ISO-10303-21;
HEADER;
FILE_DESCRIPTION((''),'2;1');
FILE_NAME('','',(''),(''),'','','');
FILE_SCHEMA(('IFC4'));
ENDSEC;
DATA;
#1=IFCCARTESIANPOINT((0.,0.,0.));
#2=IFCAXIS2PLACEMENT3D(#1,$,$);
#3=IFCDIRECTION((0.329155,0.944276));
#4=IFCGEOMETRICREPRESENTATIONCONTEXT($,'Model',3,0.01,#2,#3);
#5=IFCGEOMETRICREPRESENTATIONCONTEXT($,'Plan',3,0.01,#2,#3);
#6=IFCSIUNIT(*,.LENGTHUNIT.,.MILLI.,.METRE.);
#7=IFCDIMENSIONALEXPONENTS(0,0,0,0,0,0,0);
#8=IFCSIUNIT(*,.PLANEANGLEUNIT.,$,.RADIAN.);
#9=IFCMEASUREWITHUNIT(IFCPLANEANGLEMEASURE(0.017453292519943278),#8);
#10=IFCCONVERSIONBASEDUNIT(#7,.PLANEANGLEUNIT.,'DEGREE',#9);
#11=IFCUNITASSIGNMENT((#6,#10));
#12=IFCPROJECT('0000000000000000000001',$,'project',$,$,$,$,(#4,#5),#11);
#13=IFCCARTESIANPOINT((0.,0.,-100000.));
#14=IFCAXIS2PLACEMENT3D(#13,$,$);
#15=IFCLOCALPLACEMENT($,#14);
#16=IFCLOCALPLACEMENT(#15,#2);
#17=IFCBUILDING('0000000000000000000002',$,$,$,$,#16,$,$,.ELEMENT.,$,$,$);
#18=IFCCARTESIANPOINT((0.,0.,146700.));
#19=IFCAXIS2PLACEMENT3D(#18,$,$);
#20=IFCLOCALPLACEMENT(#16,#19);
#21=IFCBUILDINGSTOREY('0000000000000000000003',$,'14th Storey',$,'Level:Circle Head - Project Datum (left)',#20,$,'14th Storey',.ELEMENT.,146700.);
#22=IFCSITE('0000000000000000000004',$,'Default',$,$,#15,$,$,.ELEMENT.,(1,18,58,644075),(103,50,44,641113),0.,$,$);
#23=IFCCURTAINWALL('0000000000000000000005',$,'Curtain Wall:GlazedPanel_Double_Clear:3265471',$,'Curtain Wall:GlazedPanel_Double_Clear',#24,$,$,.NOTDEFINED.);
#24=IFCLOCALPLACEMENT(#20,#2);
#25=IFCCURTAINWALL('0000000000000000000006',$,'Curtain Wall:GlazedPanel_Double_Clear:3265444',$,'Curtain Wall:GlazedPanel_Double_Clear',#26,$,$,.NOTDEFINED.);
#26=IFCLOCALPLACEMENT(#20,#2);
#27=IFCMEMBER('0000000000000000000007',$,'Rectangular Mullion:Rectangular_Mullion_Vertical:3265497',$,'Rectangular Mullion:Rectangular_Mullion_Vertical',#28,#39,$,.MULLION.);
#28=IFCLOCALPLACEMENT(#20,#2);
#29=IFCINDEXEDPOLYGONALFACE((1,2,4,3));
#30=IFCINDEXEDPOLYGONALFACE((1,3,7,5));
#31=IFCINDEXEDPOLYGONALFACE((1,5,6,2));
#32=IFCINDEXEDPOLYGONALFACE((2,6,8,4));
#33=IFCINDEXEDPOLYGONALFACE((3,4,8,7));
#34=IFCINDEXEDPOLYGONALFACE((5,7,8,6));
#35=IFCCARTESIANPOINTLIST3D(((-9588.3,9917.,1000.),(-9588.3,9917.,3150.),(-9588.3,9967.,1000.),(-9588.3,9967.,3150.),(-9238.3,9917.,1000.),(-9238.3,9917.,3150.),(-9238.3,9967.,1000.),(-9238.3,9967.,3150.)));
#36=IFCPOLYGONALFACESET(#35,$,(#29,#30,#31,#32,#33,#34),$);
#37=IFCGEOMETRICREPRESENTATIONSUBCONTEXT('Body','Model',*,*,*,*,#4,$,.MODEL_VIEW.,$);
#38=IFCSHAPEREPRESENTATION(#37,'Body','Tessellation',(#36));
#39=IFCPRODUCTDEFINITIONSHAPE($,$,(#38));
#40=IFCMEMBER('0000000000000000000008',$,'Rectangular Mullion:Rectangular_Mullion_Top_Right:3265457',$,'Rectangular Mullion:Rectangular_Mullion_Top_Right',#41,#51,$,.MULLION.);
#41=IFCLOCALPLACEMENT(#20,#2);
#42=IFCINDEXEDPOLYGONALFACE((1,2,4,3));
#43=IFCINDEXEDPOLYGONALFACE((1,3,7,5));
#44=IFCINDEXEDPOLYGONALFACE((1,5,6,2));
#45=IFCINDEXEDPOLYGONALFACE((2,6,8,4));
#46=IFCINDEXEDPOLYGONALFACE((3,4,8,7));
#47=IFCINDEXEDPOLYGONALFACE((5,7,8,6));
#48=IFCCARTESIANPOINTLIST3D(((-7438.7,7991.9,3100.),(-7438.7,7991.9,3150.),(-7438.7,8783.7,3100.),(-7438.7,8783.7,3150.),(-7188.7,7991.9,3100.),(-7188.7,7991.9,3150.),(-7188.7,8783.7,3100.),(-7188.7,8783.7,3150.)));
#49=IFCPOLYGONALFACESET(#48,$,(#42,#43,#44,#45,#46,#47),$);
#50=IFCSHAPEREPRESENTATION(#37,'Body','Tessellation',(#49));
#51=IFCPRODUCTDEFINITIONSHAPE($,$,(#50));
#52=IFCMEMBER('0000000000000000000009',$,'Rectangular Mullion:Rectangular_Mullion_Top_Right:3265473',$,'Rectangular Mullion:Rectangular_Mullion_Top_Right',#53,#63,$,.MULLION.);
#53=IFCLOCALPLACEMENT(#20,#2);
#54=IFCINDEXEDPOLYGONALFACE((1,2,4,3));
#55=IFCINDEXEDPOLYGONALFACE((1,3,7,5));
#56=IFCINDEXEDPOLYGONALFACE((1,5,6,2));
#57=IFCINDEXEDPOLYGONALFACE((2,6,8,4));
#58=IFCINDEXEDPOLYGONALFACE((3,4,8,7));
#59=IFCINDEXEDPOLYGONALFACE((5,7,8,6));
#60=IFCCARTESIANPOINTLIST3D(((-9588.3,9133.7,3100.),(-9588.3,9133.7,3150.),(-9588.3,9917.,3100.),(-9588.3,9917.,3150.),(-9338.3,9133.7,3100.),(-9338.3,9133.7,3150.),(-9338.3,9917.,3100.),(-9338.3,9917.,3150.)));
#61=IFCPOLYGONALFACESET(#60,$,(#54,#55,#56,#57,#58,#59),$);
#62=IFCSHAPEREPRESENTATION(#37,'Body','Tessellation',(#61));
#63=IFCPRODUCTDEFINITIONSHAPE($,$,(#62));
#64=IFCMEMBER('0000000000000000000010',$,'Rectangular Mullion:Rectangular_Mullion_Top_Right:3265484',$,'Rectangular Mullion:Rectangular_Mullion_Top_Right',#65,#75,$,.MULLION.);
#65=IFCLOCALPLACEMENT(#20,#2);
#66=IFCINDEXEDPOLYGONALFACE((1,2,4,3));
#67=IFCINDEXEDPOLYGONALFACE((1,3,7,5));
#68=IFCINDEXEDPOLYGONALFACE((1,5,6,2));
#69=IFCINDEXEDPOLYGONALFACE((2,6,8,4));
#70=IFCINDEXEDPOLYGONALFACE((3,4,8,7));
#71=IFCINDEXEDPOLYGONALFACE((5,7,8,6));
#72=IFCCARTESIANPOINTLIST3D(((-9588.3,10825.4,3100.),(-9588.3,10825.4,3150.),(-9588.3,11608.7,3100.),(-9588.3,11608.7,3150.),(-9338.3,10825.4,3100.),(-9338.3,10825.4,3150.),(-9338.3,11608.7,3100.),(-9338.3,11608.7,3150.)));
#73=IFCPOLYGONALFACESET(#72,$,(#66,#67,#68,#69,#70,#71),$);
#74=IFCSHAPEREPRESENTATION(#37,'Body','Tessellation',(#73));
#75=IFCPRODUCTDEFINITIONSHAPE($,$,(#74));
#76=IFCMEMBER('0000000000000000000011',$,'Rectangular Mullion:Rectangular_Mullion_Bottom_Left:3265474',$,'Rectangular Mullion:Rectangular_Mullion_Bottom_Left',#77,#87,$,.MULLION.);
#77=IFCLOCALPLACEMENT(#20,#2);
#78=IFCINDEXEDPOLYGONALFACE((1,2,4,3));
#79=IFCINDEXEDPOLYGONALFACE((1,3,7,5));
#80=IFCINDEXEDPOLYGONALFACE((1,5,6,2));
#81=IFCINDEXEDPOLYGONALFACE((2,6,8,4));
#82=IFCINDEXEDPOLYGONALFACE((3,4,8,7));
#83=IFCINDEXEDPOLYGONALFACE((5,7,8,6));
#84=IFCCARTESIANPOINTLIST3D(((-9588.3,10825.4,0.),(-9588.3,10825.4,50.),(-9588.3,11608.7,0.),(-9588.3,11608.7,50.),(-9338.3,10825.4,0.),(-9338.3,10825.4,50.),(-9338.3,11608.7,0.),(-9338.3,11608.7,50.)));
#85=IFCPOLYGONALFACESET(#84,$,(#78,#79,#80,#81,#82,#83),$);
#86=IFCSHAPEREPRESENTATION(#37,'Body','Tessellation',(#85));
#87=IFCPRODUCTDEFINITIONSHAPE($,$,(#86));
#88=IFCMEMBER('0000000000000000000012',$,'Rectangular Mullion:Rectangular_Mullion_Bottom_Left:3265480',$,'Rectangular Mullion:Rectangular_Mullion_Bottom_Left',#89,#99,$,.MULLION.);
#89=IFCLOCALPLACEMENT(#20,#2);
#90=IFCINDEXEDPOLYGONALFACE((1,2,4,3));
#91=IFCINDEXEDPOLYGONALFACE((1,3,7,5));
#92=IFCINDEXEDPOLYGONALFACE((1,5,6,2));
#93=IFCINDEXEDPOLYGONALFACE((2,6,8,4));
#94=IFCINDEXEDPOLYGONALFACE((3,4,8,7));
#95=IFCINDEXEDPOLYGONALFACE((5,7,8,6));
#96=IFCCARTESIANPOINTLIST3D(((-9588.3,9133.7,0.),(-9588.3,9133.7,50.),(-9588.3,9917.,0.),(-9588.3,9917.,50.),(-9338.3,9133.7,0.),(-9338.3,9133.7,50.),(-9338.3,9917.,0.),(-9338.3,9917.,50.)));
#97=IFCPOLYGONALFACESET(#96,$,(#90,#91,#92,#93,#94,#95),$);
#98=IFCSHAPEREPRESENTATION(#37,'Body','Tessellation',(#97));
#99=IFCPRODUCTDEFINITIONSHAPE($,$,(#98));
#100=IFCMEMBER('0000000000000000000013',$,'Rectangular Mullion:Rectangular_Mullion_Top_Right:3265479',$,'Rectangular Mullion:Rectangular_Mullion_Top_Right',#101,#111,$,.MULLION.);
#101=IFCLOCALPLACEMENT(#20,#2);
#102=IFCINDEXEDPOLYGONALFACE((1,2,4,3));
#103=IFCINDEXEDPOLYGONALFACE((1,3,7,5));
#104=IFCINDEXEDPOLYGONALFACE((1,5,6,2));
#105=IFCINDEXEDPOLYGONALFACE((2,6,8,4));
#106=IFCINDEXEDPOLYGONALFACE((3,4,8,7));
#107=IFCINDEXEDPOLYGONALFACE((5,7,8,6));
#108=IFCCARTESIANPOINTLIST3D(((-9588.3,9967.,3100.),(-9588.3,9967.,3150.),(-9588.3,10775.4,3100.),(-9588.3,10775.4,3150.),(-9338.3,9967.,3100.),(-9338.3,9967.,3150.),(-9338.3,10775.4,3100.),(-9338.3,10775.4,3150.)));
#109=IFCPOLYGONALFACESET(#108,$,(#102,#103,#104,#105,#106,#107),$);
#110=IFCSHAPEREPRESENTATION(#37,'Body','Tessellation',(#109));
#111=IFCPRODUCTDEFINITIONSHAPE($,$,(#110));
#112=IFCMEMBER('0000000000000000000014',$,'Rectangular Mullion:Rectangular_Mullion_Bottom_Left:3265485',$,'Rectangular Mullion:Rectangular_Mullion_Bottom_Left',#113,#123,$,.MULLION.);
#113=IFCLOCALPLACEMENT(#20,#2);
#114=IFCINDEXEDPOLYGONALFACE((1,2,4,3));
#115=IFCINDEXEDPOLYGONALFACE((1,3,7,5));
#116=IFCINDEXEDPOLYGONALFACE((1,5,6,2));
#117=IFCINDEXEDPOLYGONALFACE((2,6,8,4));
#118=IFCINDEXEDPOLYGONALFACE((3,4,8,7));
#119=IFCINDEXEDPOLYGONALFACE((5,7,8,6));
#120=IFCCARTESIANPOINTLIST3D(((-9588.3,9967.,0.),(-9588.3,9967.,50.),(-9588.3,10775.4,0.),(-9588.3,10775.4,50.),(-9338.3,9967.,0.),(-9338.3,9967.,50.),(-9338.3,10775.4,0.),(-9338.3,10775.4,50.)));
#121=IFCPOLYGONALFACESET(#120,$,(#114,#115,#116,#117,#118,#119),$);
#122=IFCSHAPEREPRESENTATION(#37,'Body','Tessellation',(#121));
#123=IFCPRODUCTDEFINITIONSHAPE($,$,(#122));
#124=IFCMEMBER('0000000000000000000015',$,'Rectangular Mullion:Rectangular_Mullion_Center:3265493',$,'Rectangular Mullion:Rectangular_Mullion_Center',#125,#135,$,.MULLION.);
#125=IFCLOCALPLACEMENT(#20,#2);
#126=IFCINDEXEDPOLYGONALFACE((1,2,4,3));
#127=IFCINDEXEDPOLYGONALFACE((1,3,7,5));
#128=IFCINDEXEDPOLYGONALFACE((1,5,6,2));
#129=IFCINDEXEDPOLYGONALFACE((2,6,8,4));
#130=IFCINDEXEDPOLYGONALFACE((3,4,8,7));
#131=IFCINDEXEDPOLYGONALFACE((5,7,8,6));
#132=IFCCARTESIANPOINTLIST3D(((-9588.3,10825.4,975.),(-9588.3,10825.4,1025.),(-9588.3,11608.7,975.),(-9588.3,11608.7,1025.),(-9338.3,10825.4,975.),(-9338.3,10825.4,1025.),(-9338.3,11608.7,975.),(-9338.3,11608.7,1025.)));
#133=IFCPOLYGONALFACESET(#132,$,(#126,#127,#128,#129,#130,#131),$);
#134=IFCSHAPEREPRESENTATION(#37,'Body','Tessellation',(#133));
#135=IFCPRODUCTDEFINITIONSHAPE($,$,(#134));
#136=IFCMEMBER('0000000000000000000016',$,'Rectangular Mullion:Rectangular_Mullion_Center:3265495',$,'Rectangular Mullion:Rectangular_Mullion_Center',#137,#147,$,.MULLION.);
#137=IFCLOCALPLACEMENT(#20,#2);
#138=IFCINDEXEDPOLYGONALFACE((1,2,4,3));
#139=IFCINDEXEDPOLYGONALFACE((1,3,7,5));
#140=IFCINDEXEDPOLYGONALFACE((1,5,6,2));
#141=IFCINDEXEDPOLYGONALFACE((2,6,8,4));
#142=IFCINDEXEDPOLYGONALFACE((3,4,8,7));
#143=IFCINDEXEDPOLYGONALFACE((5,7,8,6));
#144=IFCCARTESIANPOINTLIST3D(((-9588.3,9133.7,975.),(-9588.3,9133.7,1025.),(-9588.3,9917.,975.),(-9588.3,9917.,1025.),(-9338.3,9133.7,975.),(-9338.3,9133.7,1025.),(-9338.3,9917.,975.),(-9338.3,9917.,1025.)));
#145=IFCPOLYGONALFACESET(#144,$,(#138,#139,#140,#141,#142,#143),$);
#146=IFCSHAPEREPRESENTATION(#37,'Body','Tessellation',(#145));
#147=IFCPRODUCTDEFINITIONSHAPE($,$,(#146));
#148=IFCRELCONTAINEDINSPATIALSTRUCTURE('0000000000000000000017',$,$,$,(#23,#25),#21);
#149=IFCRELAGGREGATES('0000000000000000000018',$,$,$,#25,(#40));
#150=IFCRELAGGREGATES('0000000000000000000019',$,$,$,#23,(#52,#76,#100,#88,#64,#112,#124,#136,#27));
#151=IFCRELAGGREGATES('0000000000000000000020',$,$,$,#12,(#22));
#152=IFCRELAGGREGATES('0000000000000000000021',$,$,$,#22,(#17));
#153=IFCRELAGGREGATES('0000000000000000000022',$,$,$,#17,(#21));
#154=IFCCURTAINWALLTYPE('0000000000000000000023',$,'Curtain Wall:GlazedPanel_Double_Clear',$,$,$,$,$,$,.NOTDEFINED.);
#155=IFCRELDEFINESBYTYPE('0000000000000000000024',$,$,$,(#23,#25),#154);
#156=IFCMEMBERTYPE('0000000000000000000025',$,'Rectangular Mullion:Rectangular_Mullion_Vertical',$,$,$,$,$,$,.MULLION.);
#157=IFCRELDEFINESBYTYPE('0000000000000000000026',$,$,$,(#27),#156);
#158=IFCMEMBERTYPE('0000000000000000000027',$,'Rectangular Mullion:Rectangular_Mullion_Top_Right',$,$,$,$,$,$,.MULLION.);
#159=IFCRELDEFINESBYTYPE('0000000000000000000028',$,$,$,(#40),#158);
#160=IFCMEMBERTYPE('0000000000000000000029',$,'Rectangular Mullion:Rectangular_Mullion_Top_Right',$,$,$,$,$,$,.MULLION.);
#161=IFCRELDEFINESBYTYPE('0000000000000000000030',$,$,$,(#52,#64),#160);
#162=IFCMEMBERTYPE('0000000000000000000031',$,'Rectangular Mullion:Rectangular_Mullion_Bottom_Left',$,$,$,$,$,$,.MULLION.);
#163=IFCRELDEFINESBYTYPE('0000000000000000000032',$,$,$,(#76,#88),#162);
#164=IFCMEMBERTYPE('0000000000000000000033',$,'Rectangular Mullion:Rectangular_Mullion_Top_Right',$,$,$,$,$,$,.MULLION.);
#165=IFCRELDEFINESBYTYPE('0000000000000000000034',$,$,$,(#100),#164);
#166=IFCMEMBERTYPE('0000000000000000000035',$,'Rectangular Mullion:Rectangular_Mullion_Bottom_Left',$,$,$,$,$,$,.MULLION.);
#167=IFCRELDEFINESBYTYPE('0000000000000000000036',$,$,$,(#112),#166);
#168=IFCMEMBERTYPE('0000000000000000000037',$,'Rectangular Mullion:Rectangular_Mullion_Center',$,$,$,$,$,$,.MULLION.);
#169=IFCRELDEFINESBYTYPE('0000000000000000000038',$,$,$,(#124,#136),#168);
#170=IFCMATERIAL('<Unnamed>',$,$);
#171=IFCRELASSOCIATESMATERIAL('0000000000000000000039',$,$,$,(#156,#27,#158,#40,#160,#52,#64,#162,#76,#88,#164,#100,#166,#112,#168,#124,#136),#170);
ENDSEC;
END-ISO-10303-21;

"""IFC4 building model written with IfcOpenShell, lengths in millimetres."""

from ifc_helpers import new_model, entity, si_unit, converted_unit, direction, frame, origin, place, context, subcontext, project, spatial, indexed_curve, outline, extrude, source, transform, mapped, material, type_object, type_shapes, element, aggregate, save


model = new_model("IFC4")

# Units and contexts
model_context = context("Model", 3, precision=0.01, world=origin(), true_north=direction((0.329155, 0.944276)))
plan_context = context("Plan", 3, precision=0.01, world=origin(), true_north=direction((0.329155, 0.944276)))
body_context = subcontext(model_context, "Body", "Model", "MODEL_VIEW")
ifc_project = project(units=[si_unit("LENGTHUNIT", "METRE", prefix="MILLI"), converted_unit("PLANEANGLEUNIT", "DEGREE", entity("IfcPlaneAngleMeasure", 0.017453292519943278), si_unit("PLANEANGLEUNIT", "RADIAN"), dimensions=[0, 0, 0, 0, 0, 0, 0])], contexts=[model_context, plan_context])

# Site, building, storey
site_placement = place(None, frame((0.0, 0.0, -100000.0)))
site = spatial("IfcSite", under=ifc_project, at=site_placement, Name="Default", CompositionType="ELEMENT", RefLatitude=(1, 18, 58, 644075), RefLongitude=(103, 50, 44, 641113), RefElevation=0.0)
building_placement = place(site_placement, origin())
building = spatial("IfcBuilding", under=site, at=building_placement, CompositionType="ELEMENT")
storey_placement = place(building_placement, frame((0.0, 0.0, 146700.0)))
storey = spatial("IfcBuildingStorey", under=building, at=storey_placement, Name="14th Storey", ObjectType="Level:Circle Head - Project Datum (left)", LongName="14th Storey", CompositionType="ELEMENT", Elevation=146700.0)

# Curtain walls
curtain_wall_type = type_object("IfcCurtainWallType", Name="Curtain Wall:GlazedPanel_Double_Clear", PredefinedType="NOTDEFINED")
curtain_wall_1_placement = place(storey_placement, frame((0.0, 0.0, -146700.0)))
curtain_wall_1 = element("IfcCurtainWall", 1, at=curtain_wall_1_placement, inside=storey, type_object=curtain_wall_type, Name="Curtain Wall:GlazedPanel_Double_Clear:3265471", ObjectType="Curtain Wall:GlazedPanel_Double_Clear", PredefinedType="NOTDEFINED")
ifc_material_1 = material(Name="<Unnamed>")
curtain_wall_2_placement = place(storey_placement, frame((0.0, 0.0, -146700.0)))
curtain_wall_2 = element("IfcCurtainWall", 2, at=curtain_wall_2_placement, inside=storey, type_object=curtain_wall_type, Name="Curtain Wall:GlazedPanel_Double_Clear:3265444", ObjectType="Curtain Wall:GlazedPanel_Double_Clear", PredefinedType="NOTDEFINED")

# Members
member_type_1 = type_object("IfcMemberType", Name="Rectangular Mullion:Rectangular_Mullion_Vertical", PredefinedType="MULLION", material=ifc_material_1)
shared_shape_1 = source(origin(), body_context, "Body", "SweptSolid", [
    extrude(outline(indexed_curve([(-25.0, -175.0), (25.0, -175.0), (25.0, 175.0), (-25.0, 175.0), (-25.0, -175.0)], self_intersect=False)), frame((0.0, -50.0, -2150.0), z_axis=(0.0, 0.0, 1.0), x_axis=(-1.0, 0.0, 0.0)), (0.0, 0.0, 1.0), 2150.0),
])
type_shapes(member_type_1, [shared_shape_1])
member_1_placement = place(curtain_wall_1_placement, frame((-9463.3, 9942.0, 147700.0), z_axis=(0.0, 0.0, -1.0), x_axis=(0.0, -1.0, 0.0)))
member_1 = element("IfcMember", 3, at=member_1_placement, type_object=member_type_1, material=ifc_material_1, Name="Rectangular Mullion:Rectangular_Mullion_Vertical:3265497", ObjectType="Rectangular Mullion:Rectangular_Mullion_Vertical", PredefinedType="MULLION", context=body_context, shape_type="MappedRepresentation", body=[
    mapped(shared_shape_1, transform((0.0, 0.0, 0.0), scale=1.0)),
])
member_type_2 = type_object("IfcMemberType", Name="Rectangular Mullion:Rectangular_Mullion_Top_Right", PredefinedType="MULLION", material=ifc_material_1)
shared_shape_2 = source(origin(), body_context, "Body", "SweptSolid", [
    extrude(outline(indexed_curve([(-25.0, -125.0), (25.0, -125.0), (25.0, 125.0), (-25.0, 125.0), (-25.0, -125.0)], self_intersect=False)), frame((-25.0, 0.0, -791.8), z_axis=(0.0, 0.0, 1.0), x_axis=(-1.0, 0.0, 0.0)), (0.0, 0.0, 1.0), 791.8),
])
type_shapes(member_type_2, [shared_shape_2])
member_2_placement = place(curtain_wall_2_placement, frame((-7313.7, 7991.9, 149850.0), z_axis=(0.0, -1.0, 0.0), x_axis=(0.0, 0.0, 1.0)))
member_2 = element("IfcMember", 4, at=member_2_placement, type_object=member_type_2, material=ifc_material_1, Name="Rectangular Mullion:Rectangular_Mullion_Top_Right:3265457", ObjectType="Rectangular Mullion:Rectangular_Mullion_Top_Right", PredefinedType="MULLION", context=body_context, shape_type="MappedRepresentation", body=[
    mapped(shared_shape_2, transform((0.0, 0.0, 0.0), scale=1.0)),
])
member_type_3 = type_object("IfcMemberType", Name="Rectangular Mullion:Rectangular_Mullion_Top_Right", PredefinedType="MULLION", material=ifc_material_1)
shared_shape_3 = source(origin(), body_context, "Body", "SweptSolid", [
    extrude(outline(indexed_curve([(-25.0, -125.0), (25.0, -125.0), (25.0, 125.0), (-25.0, 125.0), (-25.0, -125.0)], self_intersect=False)), frame((-25.0, 0.0, -783.3), z_axis=(0.0, 0.0, 1.0), x_axis=(-1.0, 0.0, 0.0)), (0.0, 0.0, 1.0), 783.3),
])
type_shapes(member_type_3, [shared_shape_3])
member_3_placement = place(curtain_wall_1_placement, frame((-9463.3, 9133.7, 149850.0), z_axis=(0.0, -1.0, 0.0), x_axis=(0.0, 0.0, 1.0)))
member_3 = element("IfcMember", 5, at=member_3_placement, type_object=member_type_3, material=ifc_material_1, Name="Rectangular Mullion:Rectangular_Mullion_Top_Right:3265473", ObjectType="Rectangular Mullion:Rectangular_Mullion_Top_Right", PredefinedType="MULLION", context=body_context, shape_type="MappedRepresentation", body=[
    mapped(shared_shape_3, transform((0.0, 0.0, 0.0), scale=1.0)),
])
member_4_placement = place(curtain_wall_1_placement, frame((-9463.3, 10825.4, 149850.0), z_axis=(0.0, -1.0, 0.0), x_axis=(0.0, 0.0, 1.0)))
member_4 = element("IfcMember", 6, at=member_4_placement, type_object=member_type_3, material=ifc_material_1, Name="Rectangular Mullion:Rectangular_Mullion_Top_Right:3265484", ObjectType="Rectangular Mullion:Rectangular_Mullion_Top_Right", PredefinedType="MULLION", context=body_context, shape_type="MappedRepresentation", body=[
    mapped(shared_shape_3, transform((0.0, 0.0, 0.0), scale=1.0)),
])
member_type_4 = type_object("IfcMemberType", Name="Rectangular Mullion:Rectangular_Mullion_Bottom_Left", PredefinedType="MULLION", material=ifc_material_1)
shared_shape_4 = source(origin(), body_context, "Body", "SweptSolid", [
    extrude(outline(indexed_curve([(-25.0, -125.0), (25.0, -125.0), (25.0, 125.0), (-25.0, 125.0), (-25.0, -125.0)], self_intersect=False)), frame((-25.0, 0.0, -783.3), z_axis=(0.0, 0.0, 1.0), x_axis=(-1.0, 0.0, 0.0)), (0.0, 0.0, 1.0), 783.3),
])
type_shapes(member_type_4, [shared_shape_4])
member_5_placement = place(curtain_wall_1_placement, frame((-9463.3, 11608.7, 146700.0), z_axis=(0.0, 1.0, 0.0), x_axis=(0.0, 0.0, -1.0)))
member_5 = element("IfcMember", 7, at=member_5_placement, type_object=member_type_4, material=ifc_material_1, Name="Rectangular Mullion:Rectangular_Mullion_Bottom_Left:3265474", ObjectType="Rectangular Mullion:Rectangular_Mullion_Bottom_Left", PredefinedType="MULLION", context=body_context, shape_type="MappedRepresentation", body=[
    mapped(shared_shape_4, transform((0.0, 0.0, 0.0), scale=1.0)),
])
member_6_placement = place(curtain_wall_1_placement, frame((-9463.3, 9917.0, 146700.0), z_axis=(0.0, 1.0, 0.0), x_axis=(0.0, 0.0, -1.0)))
member_6 = element("IfcMember", 8, at=member_6_placement, type_object=member_type_4, material=ifc_material_1, Name="Rectangular Mullion:Rectangular_Mullion_Bottom_Left:3265480", ObjectType="Rectangular Mullion:Rectangular_Mullion_Bottom_Left", PredefinedType="MULLION", context=body_context, shape_type="MappedRepresentation", body=[
    mapped(shared_shape_4, transform((0.0, 0.0, 0.0), scale=1.0)),
])
member_type_5 = type_object("IfcMemberType", Name="Rectangular Mullion:Rectangular_Mullion_Top_Right", PredefinedType="MULLION", material=ifc_material_1)
shared_shape_5 = source(origin(), body_context, "Body", "SweptSolid", [
    extrude(outline(indexed_curve([(-25.0, -125.0), (25.0, -125.0), (25.0, 125.0), (-25.0, 125.0), (-25.0, -125.0)], self_intersect=False)), frame((-25.0, 0.0, -808.3), z_axis=(0.0, 0.0, 1.0), x_axis=(-1.0, 0.0, 0.0)), (0.0, 0.0, 1.0), 808.3),
])
type_shapes(member_type_5, [shared_shape_5])
member_7_placement = place(curtain_wall_1_placement, frame((-9463.3, 9967.0, 149850.0), z_axis=(0.0, -1.0, 0.0), x_axis=(0.0, 0.0, 1.0)))
member_7 = element("IfcMember", 9, at=member_7_placement, type_object=member_type_5, material=ifc_material_1, Name="Rectangular Mullion:Rectangular_Mullion_Top_Right:3265479", ObjectType="Rectangular Mullion:Rectangular_Mullion_Top_Right", PredefinedType="MULLION", context=body_context, shape_type="MappedRepresentation", body=[
    mapped(shared_shape_5, transform((0.0, 0.0, 0.0), scale=1.0)),
])
member_type_6 = type_object("IfcMemberType", Name="Rectangular Mullion:Rectangular_Mullion_Bottom_Left", PredefinedType="MULLION", material=ifc_material_1)
shared_shape_6 = source(origin(), body_context, "Body", "SweptSolid", [
    extrude(outline(indexed_curve([(-25.0, -125.0), (25.0, -125.0), (25.0, 125.0), (-25.0, 125.0), (-25.0, -125.0)], self_intersect=False)), frame((-25.0, 0.0, -808.3), z_axis=(0.0, 0.0, 1.0), x_axis=(-1.0, 0.0, 0.0)), (0.0, 0.0, 1.0), 808.3),
])
type_shapes(member_type_6, [shared_shape_6])
member_8_placement = place(curtain_wall_1_placement, frame((-9463.3, 10775.4, 146700.0), z_axis=(0.0, 1.0, 0.0), x_axis=(0.0, 0.0, -1.0)))
member_8 = element("IfcMember", 10, at=member_8_placement, type_object=member_type_6, material=ifc_material_1, Name="Rectangular Mullion:Rectangular_Mullion_Bottom_Left:3265485", ObjectType="Rectangular Mullion:Rectangular_Mullion_Bottom_Left", PredefinedType="MULLION", context=body_context, shape_type="MappedRepresentation", body=[
    mapped(shared_shape_6, transform((0.0, 0.0, 0.0), scale=1.0)),
])
member_type_7 = type_object("IfcMemberType", Name="Rectangular Mullion:Rectangular_Mullion_Center", PredefinedType="MULLION", material=ifc_material_1)
shared_shape_7 = source(origin(), body_context, "Body", "SweptSolid", [
    extrude(outline(indexed_curve([(-25.0, -125.0), (25.0, -125.0), (25.0, 125.0), (-25.0, 125.0), (-25.0, -125.0)], self_intersect=False)), frame((0.0, 0.0, -783.3), z_axis=(0.0, 0.0, 1.0), x_axis=(-1.0, 0.0, 0.0)), (0.0, 0.0, 1.0), 783.3),
])
type_shapes(member_type_7, [shared_shape_7])
member_9_placement = place(curtain_wall_1_placement, frame((-9463.3, 10825.4, 147700.0), z_axis=(0.0, -1.0, 0.0), x_axis=(0.0, 0.0, 1.0)))
member_9 = element("IfcMember", 11, at=member_9_placement, type_object=member_type_7, material=ifc_material_1, Name="Rectangular Mullion:Rectangular_Mullion_Center:3265493", ObjectType="Rectangular Mullion:Rectangular_Mullion_Center", PredefinedType="MULLION", context=body_context, shape_type="MappedRepresentation", body=[
    mapped(shared_shape_7, transform((0.0, 0.0, 0.0), scale=1.0)),
])
member_10_placement = place(curtain_wall_1_placement, frame((-9463.3, 9133.7, 147700.0), z_axis=(0.0, -1.0, 0.0), x_axis=(0.0, 0.0, 1.0)))
member_10 = element("IfcMember", 12, at=member_10_placement, type_object=member_type_7, material=ifc_material_1, Name="Rectangular Mullion:Rectangular_Mullion_Center:3265495", ObjectType="Rectangular Mullion:Rectangular_Mullion_Center", PredefinedType="MULLION", context=body_context, shape_type="MappedRepresentation", body=[
    mapped(shared_shape_7, transform((0.0, 0.0, 0.0), scale=1.0)),
])

aggregate(curtain_wall_2, [member_2])
aggregate(curtain_wall_1, [member_3, member_5, member_7, member_6, member_4, member_8, member_9, member_10, member_1])

save(model, "model.ifc")
